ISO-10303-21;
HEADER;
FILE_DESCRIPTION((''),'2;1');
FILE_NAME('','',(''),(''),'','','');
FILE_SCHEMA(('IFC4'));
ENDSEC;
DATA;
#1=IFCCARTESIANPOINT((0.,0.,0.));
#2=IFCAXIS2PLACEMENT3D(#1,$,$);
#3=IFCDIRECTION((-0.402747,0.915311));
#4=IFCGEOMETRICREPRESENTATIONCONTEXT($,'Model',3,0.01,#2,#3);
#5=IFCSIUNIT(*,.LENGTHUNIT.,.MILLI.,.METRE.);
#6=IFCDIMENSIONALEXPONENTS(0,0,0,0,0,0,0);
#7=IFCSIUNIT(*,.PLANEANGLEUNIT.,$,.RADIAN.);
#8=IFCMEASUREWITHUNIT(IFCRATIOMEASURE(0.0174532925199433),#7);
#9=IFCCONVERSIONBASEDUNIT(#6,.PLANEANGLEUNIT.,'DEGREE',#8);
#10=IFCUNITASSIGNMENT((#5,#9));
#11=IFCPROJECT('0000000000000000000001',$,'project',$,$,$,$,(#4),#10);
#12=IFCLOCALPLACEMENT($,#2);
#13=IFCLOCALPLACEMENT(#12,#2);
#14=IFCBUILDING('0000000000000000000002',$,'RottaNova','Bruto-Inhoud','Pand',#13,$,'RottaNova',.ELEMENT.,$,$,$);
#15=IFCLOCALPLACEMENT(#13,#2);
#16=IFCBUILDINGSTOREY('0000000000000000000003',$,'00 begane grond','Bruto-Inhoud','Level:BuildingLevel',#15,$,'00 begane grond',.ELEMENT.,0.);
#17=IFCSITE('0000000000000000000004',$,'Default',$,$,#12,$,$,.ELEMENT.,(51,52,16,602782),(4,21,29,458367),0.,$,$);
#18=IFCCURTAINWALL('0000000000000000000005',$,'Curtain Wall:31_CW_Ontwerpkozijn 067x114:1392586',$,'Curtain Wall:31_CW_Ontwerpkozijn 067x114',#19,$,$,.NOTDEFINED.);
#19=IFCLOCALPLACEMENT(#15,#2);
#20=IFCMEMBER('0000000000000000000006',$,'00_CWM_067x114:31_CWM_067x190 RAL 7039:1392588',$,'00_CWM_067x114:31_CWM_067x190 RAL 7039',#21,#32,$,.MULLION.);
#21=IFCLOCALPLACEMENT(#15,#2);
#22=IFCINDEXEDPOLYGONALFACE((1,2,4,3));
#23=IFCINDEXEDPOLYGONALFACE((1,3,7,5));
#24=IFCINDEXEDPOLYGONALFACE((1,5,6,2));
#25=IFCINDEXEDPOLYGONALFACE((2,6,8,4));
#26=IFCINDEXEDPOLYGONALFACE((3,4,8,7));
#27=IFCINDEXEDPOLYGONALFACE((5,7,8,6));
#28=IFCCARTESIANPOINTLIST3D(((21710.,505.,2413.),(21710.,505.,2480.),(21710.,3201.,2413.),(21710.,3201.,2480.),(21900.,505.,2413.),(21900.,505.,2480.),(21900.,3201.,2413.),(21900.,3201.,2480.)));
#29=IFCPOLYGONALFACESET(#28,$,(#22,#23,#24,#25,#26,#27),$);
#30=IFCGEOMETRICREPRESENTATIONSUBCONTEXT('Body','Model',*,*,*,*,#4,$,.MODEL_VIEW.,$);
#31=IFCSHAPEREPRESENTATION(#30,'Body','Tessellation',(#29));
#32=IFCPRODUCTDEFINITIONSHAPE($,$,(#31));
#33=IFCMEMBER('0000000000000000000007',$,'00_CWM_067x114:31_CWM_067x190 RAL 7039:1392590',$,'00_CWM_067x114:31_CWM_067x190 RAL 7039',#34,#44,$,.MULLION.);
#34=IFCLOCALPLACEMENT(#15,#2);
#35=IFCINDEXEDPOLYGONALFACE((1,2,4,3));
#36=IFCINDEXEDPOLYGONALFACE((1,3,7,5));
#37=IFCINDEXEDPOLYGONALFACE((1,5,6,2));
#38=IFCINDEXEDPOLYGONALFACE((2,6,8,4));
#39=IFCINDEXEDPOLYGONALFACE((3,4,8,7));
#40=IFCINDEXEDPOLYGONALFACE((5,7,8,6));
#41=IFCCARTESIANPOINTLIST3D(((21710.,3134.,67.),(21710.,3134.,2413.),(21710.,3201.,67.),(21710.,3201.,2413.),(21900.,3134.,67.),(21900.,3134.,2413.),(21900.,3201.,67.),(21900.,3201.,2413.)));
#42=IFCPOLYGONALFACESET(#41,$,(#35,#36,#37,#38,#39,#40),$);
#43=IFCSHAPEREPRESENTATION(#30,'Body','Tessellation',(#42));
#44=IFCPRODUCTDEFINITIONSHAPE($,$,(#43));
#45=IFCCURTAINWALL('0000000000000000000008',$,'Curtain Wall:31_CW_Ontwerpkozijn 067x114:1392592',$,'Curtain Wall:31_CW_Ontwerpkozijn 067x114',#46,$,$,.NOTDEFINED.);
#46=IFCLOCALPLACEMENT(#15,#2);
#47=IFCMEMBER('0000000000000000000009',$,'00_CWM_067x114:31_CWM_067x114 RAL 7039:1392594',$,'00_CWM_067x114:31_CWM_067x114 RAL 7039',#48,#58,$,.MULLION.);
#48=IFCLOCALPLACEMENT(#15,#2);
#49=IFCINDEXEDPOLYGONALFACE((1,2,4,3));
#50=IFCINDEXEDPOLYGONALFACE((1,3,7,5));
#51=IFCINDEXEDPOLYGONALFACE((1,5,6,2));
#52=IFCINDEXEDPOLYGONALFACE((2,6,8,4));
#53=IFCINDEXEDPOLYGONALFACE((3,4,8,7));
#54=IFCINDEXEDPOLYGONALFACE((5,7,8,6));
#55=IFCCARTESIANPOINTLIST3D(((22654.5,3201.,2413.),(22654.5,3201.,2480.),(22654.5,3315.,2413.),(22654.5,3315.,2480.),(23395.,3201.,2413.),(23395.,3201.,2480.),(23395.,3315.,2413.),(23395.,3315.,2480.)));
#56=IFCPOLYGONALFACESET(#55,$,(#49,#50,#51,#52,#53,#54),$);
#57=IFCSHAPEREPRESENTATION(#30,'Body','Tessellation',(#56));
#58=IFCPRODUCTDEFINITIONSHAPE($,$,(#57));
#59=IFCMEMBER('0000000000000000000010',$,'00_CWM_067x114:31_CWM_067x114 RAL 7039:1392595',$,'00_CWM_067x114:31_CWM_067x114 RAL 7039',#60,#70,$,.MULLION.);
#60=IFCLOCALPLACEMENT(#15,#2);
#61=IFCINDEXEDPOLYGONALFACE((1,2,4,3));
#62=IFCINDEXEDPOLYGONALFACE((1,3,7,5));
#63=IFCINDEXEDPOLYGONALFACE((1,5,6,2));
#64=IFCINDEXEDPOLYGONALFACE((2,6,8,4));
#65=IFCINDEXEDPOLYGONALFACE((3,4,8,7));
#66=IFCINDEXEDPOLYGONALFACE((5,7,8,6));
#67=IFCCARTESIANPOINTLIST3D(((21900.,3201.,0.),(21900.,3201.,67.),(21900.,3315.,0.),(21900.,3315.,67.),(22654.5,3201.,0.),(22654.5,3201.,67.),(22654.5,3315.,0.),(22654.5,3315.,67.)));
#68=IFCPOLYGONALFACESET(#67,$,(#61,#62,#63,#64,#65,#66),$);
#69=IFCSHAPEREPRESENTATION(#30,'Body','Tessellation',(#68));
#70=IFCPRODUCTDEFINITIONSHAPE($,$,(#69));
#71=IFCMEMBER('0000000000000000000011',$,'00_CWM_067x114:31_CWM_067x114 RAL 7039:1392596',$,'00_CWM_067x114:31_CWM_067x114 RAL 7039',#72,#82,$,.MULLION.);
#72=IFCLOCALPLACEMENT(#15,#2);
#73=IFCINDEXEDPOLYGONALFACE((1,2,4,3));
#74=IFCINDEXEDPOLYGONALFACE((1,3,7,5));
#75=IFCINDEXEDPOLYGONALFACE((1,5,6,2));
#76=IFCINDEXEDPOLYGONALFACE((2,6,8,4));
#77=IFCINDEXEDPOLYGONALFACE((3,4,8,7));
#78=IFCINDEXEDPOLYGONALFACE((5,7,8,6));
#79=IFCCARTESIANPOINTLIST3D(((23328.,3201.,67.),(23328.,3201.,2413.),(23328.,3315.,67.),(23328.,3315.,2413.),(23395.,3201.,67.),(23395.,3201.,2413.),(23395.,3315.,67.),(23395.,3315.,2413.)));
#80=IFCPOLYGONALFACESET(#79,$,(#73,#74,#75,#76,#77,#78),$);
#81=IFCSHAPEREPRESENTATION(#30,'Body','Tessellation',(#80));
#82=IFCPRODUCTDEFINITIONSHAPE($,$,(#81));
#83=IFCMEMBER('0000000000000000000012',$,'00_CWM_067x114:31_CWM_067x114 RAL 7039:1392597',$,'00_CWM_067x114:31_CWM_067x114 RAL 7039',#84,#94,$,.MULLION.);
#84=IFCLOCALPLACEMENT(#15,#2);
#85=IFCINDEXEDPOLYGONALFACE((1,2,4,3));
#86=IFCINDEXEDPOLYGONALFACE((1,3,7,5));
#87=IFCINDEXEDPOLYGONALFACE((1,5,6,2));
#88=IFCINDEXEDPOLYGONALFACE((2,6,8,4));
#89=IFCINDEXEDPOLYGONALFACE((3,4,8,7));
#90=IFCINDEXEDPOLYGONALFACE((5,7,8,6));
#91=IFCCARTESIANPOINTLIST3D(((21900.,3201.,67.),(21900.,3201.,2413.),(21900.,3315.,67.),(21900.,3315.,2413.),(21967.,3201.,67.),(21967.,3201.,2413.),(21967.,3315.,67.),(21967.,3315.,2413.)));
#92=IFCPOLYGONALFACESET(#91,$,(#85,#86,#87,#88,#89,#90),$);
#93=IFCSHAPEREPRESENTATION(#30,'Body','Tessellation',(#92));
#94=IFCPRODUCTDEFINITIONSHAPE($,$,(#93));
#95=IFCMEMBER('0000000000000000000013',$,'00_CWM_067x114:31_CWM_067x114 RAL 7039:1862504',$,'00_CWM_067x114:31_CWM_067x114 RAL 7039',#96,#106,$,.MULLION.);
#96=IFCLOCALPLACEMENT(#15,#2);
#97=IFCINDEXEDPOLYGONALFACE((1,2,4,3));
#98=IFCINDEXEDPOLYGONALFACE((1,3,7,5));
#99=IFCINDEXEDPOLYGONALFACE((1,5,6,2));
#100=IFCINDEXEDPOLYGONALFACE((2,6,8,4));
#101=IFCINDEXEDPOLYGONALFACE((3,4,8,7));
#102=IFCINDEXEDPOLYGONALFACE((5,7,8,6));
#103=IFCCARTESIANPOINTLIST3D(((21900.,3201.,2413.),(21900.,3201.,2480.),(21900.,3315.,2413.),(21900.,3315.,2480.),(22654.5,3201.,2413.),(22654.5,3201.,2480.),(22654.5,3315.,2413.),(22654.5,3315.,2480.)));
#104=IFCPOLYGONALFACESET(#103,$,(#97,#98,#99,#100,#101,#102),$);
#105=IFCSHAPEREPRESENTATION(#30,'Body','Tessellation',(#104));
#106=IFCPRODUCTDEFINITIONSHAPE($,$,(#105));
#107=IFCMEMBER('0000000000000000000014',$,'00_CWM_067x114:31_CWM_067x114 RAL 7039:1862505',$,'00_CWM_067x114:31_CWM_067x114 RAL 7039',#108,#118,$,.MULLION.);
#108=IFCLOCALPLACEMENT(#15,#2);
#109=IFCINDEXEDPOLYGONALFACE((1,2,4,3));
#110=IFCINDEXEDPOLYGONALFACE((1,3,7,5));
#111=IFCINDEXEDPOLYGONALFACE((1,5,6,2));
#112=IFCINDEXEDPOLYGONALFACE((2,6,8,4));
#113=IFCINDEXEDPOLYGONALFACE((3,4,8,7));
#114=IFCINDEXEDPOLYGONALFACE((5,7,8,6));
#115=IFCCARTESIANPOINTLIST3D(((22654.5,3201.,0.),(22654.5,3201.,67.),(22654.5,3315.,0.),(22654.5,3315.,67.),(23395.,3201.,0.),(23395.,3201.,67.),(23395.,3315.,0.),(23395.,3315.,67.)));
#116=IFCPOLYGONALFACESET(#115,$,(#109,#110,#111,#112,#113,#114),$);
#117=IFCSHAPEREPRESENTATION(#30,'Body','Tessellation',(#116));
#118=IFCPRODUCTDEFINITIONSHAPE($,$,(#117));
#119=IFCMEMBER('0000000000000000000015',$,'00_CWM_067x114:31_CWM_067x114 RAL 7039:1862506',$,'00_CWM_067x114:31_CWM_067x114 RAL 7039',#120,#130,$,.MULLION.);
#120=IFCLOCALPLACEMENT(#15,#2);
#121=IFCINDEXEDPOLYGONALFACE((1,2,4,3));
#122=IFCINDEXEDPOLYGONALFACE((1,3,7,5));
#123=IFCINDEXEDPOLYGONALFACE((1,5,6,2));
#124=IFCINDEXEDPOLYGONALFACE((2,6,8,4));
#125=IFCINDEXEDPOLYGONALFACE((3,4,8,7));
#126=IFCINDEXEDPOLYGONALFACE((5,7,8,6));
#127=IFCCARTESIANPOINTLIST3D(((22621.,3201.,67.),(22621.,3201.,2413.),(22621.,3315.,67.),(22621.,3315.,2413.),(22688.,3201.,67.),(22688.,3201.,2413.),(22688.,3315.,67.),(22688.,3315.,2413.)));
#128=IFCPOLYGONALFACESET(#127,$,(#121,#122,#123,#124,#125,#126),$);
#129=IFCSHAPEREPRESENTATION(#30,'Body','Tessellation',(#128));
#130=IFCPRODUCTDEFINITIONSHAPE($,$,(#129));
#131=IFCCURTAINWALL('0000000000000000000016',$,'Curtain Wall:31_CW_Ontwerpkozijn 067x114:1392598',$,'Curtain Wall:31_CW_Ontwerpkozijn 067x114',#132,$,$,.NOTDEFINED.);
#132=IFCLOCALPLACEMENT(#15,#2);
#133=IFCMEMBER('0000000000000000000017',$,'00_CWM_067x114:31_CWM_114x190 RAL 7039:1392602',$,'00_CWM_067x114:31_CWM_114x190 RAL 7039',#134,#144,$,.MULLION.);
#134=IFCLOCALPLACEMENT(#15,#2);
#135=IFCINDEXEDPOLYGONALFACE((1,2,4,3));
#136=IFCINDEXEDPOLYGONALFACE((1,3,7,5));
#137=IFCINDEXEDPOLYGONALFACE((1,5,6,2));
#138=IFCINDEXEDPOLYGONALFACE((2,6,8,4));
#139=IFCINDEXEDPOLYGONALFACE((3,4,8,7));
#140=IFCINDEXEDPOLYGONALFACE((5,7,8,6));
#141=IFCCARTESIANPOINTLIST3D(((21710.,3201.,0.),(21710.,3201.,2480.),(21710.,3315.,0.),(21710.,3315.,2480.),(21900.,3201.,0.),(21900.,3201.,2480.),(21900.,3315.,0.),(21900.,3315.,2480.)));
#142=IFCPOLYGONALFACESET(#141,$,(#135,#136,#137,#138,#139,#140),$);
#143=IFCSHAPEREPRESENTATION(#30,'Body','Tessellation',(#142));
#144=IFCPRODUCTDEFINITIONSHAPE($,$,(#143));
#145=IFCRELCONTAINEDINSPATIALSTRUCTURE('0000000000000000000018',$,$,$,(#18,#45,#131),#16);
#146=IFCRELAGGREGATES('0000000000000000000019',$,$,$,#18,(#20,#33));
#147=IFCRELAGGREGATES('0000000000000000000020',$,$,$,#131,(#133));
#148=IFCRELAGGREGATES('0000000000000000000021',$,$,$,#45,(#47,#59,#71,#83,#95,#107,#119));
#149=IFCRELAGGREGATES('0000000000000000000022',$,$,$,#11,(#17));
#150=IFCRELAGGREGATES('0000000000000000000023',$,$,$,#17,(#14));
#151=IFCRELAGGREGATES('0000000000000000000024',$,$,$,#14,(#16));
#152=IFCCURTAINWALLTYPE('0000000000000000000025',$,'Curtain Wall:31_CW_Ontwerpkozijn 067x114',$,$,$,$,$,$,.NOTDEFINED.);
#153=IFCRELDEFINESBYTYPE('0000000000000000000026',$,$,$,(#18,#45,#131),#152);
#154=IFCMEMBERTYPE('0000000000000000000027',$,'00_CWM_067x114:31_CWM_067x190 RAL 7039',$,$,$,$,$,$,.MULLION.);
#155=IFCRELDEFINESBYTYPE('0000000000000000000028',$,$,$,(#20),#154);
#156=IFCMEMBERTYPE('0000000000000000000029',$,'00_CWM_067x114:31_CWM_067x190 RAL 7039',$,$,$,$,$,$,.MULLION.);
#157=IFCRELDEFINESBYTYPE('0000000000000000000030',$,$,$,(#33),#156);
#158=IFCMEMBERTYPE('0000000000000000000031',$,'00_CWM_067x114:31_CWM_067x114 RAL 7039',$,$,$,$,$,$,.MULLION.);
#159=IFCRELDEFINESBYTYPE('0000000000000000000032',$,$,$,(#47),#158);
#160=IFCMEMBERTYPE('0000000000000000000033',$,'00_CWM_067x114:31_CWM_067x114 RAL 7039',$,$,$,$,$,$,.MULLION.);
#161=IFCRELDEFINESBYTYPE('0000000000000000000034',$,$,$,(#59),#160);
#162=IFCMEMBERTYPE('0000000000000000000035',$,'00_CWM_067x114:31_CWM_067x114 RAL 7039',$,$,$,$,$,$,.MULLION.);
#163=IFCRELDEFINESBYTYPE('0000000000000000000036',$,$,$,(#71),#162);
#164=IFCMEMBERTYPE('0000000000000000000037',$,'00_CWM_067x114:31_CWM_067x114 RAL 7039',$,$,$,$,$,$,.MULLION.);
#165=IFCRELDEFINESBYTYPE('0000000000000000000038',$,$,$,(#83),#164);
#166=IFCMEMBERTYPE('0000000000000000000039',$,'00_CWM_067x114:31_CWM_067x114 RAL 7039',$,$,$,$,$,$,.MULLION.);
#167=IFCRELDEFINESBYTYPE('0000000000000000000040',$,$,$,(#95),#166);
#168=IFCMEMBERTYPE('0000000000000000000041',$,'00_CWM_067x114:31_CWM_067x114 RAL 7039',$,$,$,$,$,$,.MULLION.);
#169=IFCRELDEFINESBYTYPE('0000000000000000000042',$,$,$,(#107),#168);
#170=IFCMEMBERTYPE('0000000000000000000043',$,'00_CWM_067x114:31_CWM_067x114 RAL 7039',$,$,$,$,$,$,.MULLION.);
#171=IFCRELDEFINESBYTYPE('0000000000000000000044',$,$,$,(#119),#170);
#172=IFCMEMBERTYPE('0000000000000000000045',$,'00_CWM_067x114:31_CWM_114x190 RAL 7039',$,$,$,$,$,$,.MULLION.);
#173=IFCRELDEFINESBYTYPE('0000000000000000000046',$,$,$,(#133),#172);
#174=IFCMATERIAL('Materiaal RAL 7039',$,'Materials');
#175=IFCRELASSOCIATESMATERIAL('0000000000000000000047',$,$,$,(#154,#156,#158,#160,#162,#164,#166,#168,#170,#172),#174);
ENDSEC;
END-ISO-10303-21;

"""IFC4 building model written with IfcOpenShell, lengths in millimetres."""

from ifc_helpers import new_model, entity, si_unit, converted_unit, direction, frame, origin, origin_2d_with_axis, place, context, subcontext, project, spatial, rectangle, extrude, source, transform, mapped, material, material_profile, profile_set, type_object, type_shapes, element, aggregate, save


model = new_model("IFC4")

# Units and contexts
model_context = context("Model", 3, precision=0.01, world=origin(), true_north=direction((-0.402747, 0.915311)))
body_context = subcontext(model_context, "Body", "Model", "MODEL_VIEW")
ifc_project = project(units=[si_unit("LENGTHUNIT", "METRE", prefix="MILLI"), converted_unit("PLANEANGLEUNIT", "DEGREE", entity("IfcRatioMeasure", 0.0174532925199433), si_unit("PLANEANGLEUNIT", "RADIAN"), dimensions=[0, 0, 0, 0, 0, 0, 0])], contexts=[model_context])

# Site, building, storey
site_placement = place(None, origin())
site = spatial("IfcSite", under=ifc_project, at=site_placement, Name="Default", CompositionType="ELEMENT", RefLatitude=(51, 52, 16, 602782), RefLongitude=(4, 21, 29, 458367), RefElevation=0.0)
building_placement = place(site_placement, origin())
building = spatial("IfcBuilding", under=site, at=building_placement, Name="RottaNova", Description="Bruto-Inhoud", ObjectType="Pand", LongName="RottaNova", CompositionType="ELEMENT")
storey_placement = place(building_placement, origin())
storey = spatial("IfcBuildingStorey", under=building, at=storey_placement, Name="00 begane grond", Description="Bruto-Inhoud", ObjectType="Level:BuildingLevel", LongName="00 begane grond", CompositionType="ELEMENT", Elevation=0.0)

# Curtain walls, members
curtain_wall_type = type_object("IfcCurtainWallType", Name="Curtain Wall:31_CW_Ontwerpkozijn 067x114", PredefinedType="NOTDEFINED")
curtain_wall_1_placement = place(storey_placement, origin())
curtain_wall_1 = element("IfcCurtainWall", 1, at=curtain_wall_1_placement, inside=storey, type_object=curtain_wall_type, Name="Curtain Wall:31_CW_Ontwerpkozijn 067x114:1392586", ObjectType="Curtain Wall:31_CW_Ontwerpkozijn 067x114", PredefinedType="NOTDEFINED")
ifc_material_1 = material(Name="Materiaal RAL 7039", Category="Materials")
ifc_material_profile_1 = material_profile(ifc_material_1, rectangle(XDim=190.0, YDim=67.0, at=origin_2d_with_axis()), Name="31_CWM_067x190 RAL 7039")
ifc_profile_set_1 = profile_set([ifc_material_profile_1], Name="31_CWM_067x190 RAL 7039")
member_type_1 = type_object("IfcMemberType", Name="00_CWM_067x114:31_CWM_067x190 RAL 7039", PredefinedType="MULLION", material=ifc_profile_set_1)
shared_shape_1 = source(origin(), body_context, "Body", "SweptSolid", [
    extrude(rectangle(XDim=190.0, YDim=67.0, at=origin_2d_with_axis()), frame((-33.5, 95.0, -2696.0), z_axis=(0.0, 0.0, 1.0), x_axis=(0.0, -1.0, 0.0)), (0.0, 0.0, 1.0), 2696.0),
])
type_shapes(member_type_1, [shared_shape_1])
member_1_placement = place(curtain_wall_1_placement, frame((21710.0, 3201.0, 2480.0), z_axis=(0.0, 1.0, 0.0), x_axis=(0.0, 0.0, 1.0)))
member_1 = element("IfcMember", 2, at=member_1_placement, type_object=member_type_1, Name="00_CWM_067x114:31_CWM_067x190 RAL 7039:1392588", ObjectType="00_CWM_067x114:31_CWM_067x190 RAL 7039", PredefinedType="MULLION", context=body_context, shape_type="MappedRepresentation", body=[
    mapped(shared_shape_1, transform((0.0, 0.0, 0.0), scale=1.0)),
])
member_type_2 = type_object("IfcMemberType", Name="00_CWM_067x114:31_CWM_067x190 RAL 7039", PredefinedType="MULLION", material=ifc_profile_set_1)
shared_shape_2 = source(origin(), body_context, "Body", "SweptSolid", [
    extrude(rectangle(XDim=190.0, YDim=67.0, at=origin_2d_with_axis()), frame((-33.5, 95.0, -2346.0), z_axis=(0.0, 0.0, 1.0), x_axis=(0.0, -1.0, 0.0)), (0.0, 0.0, 1.0), 2346.0),
])
type_shapes(member_type_2, [shared_shape_2])
member_2_placement = place(curtain_wall_1_placement, frame((21710.0, 3201.0, 67.0), z_axis=(0.0, 0.0, -1.0), x_axis=(0.0, 1.0, 0.0)))
member_2 = element("IfcMember", 3, at=member_2_placement, type_object=member_type_2, Name="00_CWM_067x114:31_CWM_067x190 RAL 7039:1392590", ObjectType="00_CWM_067x114:31_CWM_067x190 RAL 7039", PredefinedType="MULLION", context=body_context, shape_type="MappedRepresentation", body=[
    mapped(shared_shape_2, transform((0.0, 0.0, 0.0), scale=1.0)),
])
aggregate(curtain_wall_1, [member_1, member_2])
curtain_wall_2_placement = place(storey_placement, origin())
curtain_wall_2 = element("IfcCurtainWall", 4, at=curtain_wall_2_placement, inside=storey, type_object=curtain_wall_type, Name="Curtain Wall:31_CW_Ontwerpkozijn 067x114:1392592", ObjectType="Curtain Wall:31_CW_Ontwerpkozijn 067x114", PredefinedType="NOTDEFINED")
ifc_material_profile_2 = material_profile(ifc_material_1, rectangle(XDim=114.0, YDim=67.0, at=origin_2d_with_axis()), Name="31_CWM_067x114 RAL 7039")
ifc_profile_set_2 = profile_set([ifc_material_profile_2], Name="31_CWM_067x114 RAL 7039")
member_type_3 = type_object("IfcMemberType", Name="00_CWM_067x114:31_CWM_067x114 RAL 7039", PredefinedType="MULLION", material=ifc_profile_set_2)
shared_shape_3 = source(origin(), body_context, "Body", "SweptSolid", [
    extrude(rectangle(XDim=114.0, YDim=67.0, at=origin_2d_with_axis()), frame((-33.5, 57.0, -740.5), z_axis=(0.0, 0.0, 1.0), x_axis=(0.0, -1.0, 0.0)), (0.0, 0.0, 1.0), 740.5),
])
type_shapes(member_type_3, [shared_shape_3])
member_3_placement = place(curtain_wall_2_placement, frame((23395.0, 3315.0, 2480.0), z_axis=(1.0, 0.0, 0.0), x_axis=(0.0, 0.0, 1.0)))
member_3 = element("IfcMember", 5, at=member_3_placement, type_object=member_type_3, Name="00_CWM_067x114:31_CWM_067x114 RAL 7039:1392594", ObjectType="00_CWM_067x114:31_CWM_067x114 RAL 7039", PredefinedType="MULLION", context=body_context, shape_type="MappedRepresentation", body=[
    mapped(shared_shape_3, transform((0.0, 0.0, 0.0), scale=1.0)),
])
member_type_4 = type_object("IfcMemberType", Name="00_CWM_067x114:31_CWM_067x114 RAL 7039", PredefinedType="MULLION", material=ifc_profile_set_2)
shared_shape_4 = source(origin(), body_context, "Body", "SweptSolid", [
    extrude(rectangle(XDim=114.0, YDim=67.0, at=origin_2d_with_axis()), frame((-33.5, 57.0, -754.5), z_axis=(0.0, 0.0, 1.0), x_axis=(0.0, -1.0, 0.0)), (0.0, 0.0, 1.0), 754.5),
])
type_shapes(member_type_4, [shared_shape_4])
member_4_placement = place(curtain_wall_2_placement, frame((21900.0, 3315.0, 0.0), z_axis=(-1.0, 0.0, 0.0), x_axis=(0.0, 0.0, -1.0)))
member_4 = element("IfcMember", 6, at=member_4_placement, type_object=member_type_4, Name="00_CWM_067x114:31_CWM_067x114 RAL 7039:1392595", ObjectType="00_CWM_067x114:31_CWM_067x114 RAL 7039", PredefinedType="MULLION", context=body_context, shape_type="MappedRepresentation", body=[
    mapped(shared_shape_4, transform((0.0, 0.0, 0.0), scale=1.0)),
])
member_type_5 = type_object("IfcMemberType", Name="00_CWM_067x114:31_CWM_067x114 RAL 7039", PredefinedType="MULLION", material=ifc_profile_set_2)
shared_shape_5 = source(origin(), body_context, "Body", "SweptSolid", [
    extrude(rectangle(XDim=114.0, YDim=67.0, at=origin_2d_with_axis()), frame((-33.5, 57.0, -2346.0), z_axis=(0.0, 0.0, 1.0), x_axis=(0.0, -1.0, 0.0)), (0.0, 0.0, 1.0), 2346.0),
])
type_shapes(member_type_5, [shared_shape_5])
member_5_placement = place(curtain_wall_2_placement, frame((23395.0, 3315.0, 67.0), z_axis=(0.0, 0.0, -1.0), x_axis=(1.0, 0.0, 0.0)))
member_5 = element("IfcMember", 7, at=member_5_placement, type_object=member_type_5, Name="00_CWM_067x114:31_CWM_067x114 RAL 7039:1392596", ObjectType="00_CWM_067x114:31_CWM_067x114 RAL 7039", PredefinedType="MULLION", context=body_context, shape_type="MappedRepresentation", body=[
    mapped(shared_shape_5, transform((0.0, 0.0, 0.0), scale=1.0)),
])
member_type_6 = type_object("IfcMemberType", Name="00_CWM_067x114:31_CWM_067x114 RAL 7039", PredefinedType="MULLION", material=ifc_profile_set_2)
shared_shape_6 = source(origin(), body_context, "Body", "SweptSolid", [
    extrude(rectangle(XDim=114.0, YDim=67.0, at=origin_2d_with_axis()), frame((-33.5, 57.0, -2346.0), z_axis=(0.0, 0.0, 1.0), x_axis=(0.0, -1.0, 0.0)), (0.0, 0.0, 1.0), 2346.0),
])
type_shapes(member_type_6, [shared_shape_6])
member_6_placement = place(curtain_wall_2_placement, frame((21900.0, 3315.0, 2413.0), z_axis=(0.0, 0.0, 1.0), x_axis=(-1.0, 0.0, 0.0)))
member_6 = element("IfcMember", 8, at=member_6_placement, type_object=member_type_6, Name="00_CWM_067x114:31_CWM_067x114 RAL 7039:1392597", ObjectType="00_CWM_067x114:31_CWM_067x114 RAL 7039", PredefinedType="MULLION", context=body_context, shape_type="MappedRepresentation", body=[
    mapped(shared_shape_6, transform((0.0, 0.0, 0.0), scale=1.0)),
])
member_type_7 = type_object("IfcMemberType", Name="00_CWM_067x114:31_CWM_067x114 RAL 7039", PredefinedType="MULLION", material=ifc_profile_set_2)
shared_shape_7 = source(origin(), body_context, "Body", "SweptSolid", [
    extrude(rectangle(XDim=114.0, YDim=67.0, at=origin_2d_with_axis()), frame((-33.5, 57.0, -754.5), z_axis=(0.0, 0.0, 1.0), x_axis=(0.0, -1.0, 0.0)), (0.0, 0.0, 1.0), 754.5),
])
type_shapes(member_type_7, [shared_shape_7])
member_7_placement = place(curtain_wall_2_placement, frame((22654.5, 3315.0, 2480.0), z_axis=(1.0, 0.0, 0.0), x_axis=(0.0, 0.0, 1.0)))
member_7 = element("IfcMember", 9, at=member_7_placement, type_object=member_type_7, Name="00_CWM_067x114:31_CWM_067x114 RAL 7039:1862504", ObjectType="00_CWM_067x114:31_CWM_067x114 RAL 7039", PredefinedType="MULLION", context=body_context, shape_type="MappedRepresentation", body=[
    mapped(shared_shape_7, transform((0.0, 0.0, 0.0), scale=1.0)),
])
member_type_8 = type_object("IfcMemberType", Name="00_CWM_067x114:31_CWM_067x114 RAL 7039", PredefinedType="MULLION", material=ifc_profile_set_2)
shared_shape_8 = source(origin(), body_context, "Body", "SweptSolid", [
    extrude(rectangle(XDim=114.0, YDim=67.0, at=origin_2d_with_axis()), frame((-33.5, 57.0, -740.5), z_axis=(0.0, 0.0, 1.0), x_axis=(0.0, -1.0, 0.0)), (0.0, 0.0, 1.0), 740.5),
])
type_shapes(member_type_8, [shared_shape_8])
member_8_placement = place(curtain_wall_2_placement, frame((22654.5, 3315.0, 0.0), z_axis=(-1.0, 0.0, 0.0), x_axis=(0.0, 0.0, -1.0)))
member_8 = element("IfcMember", 10, at=member_8_placement, type_object=member_type_8, Name="00_CWM_067x114:31_CWM_067x114 RAL 7039:1862505", ObjectType="00_CWM_067x114:31_CWM_067x114 RAL 7039", PredefinedType="MULLION", context=body_context, shape_type="MappedRepresentation", body=[
    mapped(shared_shape_8, transform((0.0, 0.0, 0.0), scale=1.0)),
])
member_type_9 = type_object("IfcMemberType", Name="00_CWM_067x114:31_CWM_067x114 RAL 7039", PredefinedType="MULLION", material=ifc_profile_set_2)
shared_shape_9 = source(origin(), body_context, "Body", "SweptSolid", [
    extrude(rectangle(XDim=114.0, YDim=67.0, at=origin_2d_with_axis()), frame((0.0, 57.0, -2346.0), z_axis=(0.0, 0.0, 1.0), x_axis=(0.0, -1.0, 0.0)), (0.0, 0.0, 1.0), 2346.0),
])
type_shapes(member_type_9, [shared_shape_9])
member_9_placement = place(curtain_wall_2_placement, frame((22654.5, 3315.0, 67.0), z_axis=(0.0, 0.0, -1.0), x_axis=(1.0, 0.0, 0.0)))
member_9 = element("IfcMember", 11, at=member_9_placement, type_object=member_type_9, Name="00_CWM_067x114:31_CWM_067x114 RAL 7039:1862506", ObjectType="00_CWM_067x114:31_CWM_067x114 RAL 7039", PredefinedType="MULLION", context=body_context, shape_type="MappedRepresentation", body=[
    mapped(shared_shape_9, transform((0.0, 0.0, 0.0), scale=1.0)),
])

# Curtain wall, member
curtain_wall_3_placement = place(storey_placement, origin())
curtain_wall_3 = element("IfcCurtainWall", 12, at=curtain_wall_3_placement, inside=storey, type_object=curtain_wall_type, Name="Curtain Wall:31_CW_Ontwerpkozijn 067x114:1392598", ObjectType="Curtain Wall:31_CW_Ontwerpkozijn 067x114", PredefinedType="NOTDEFINED")
ifc_material_profile_3 = material_profile(ifc_material_1, rectangle(XDim=114.0, YDim=190.0, at=origin_2d_with_axis()), Name="31_CWM_114x190 RAL 7039")
ifc_profile_set_3 = profile_set([ifc_material_profile_3], Name="31_CWM_114x190 RAL 7039")
member_type_10 = type_object("IfcMemberType", Name="00_CWM_067x114:31_CWM_114x190 RAL 7039", PredefinedType="MULLION", material=ifc_profile_set_3)
shared_shape_10 = source(origin(), body_context, "Body", "SweptSolid", [
    extrude(rectangle(XDim=114.0, YDim=190.0, at=origin_2d_with_axis()), frame((-95.0, 0.0, -2480.0), z_axis=(0.0, 0.0, 1.0), x_axis=(0.0, -1.0, 0.0)), (0.0, 0.0, 1.0), 2480.0),
])
type_shapes(member_type_10, [shared_shape_10])
member_10_placement = place(curtain_wall_3_placement, frame((21710.0, 3258.0, 2480.0), z_axis=(0.0, 0.0, 1.0), x_axis=(-1.0, 0.0, 0.0)))
member_10 = element("IfcMember", 13, at=member_10_placement, type_object=member_type_10, Name="00_CWM_067x114:31_CWM_114x190 RAL 7039:1392602", ObjectType="00_CWM_067x114:31_CWM_114x190 RAL 7039", PredefinedType="MULLION", context=body_context, shape_type="MappedRepresentation", body=[
    mapped(shared_shape_10, transform((0.0, 0.0, 0.0), scale=1.0)),
])
aggregate(curtain_wall_3, [member_10])

aggregate(curtain_wall_2, [member_3, member_4, member_5, member_6, member_7, member_8, member_9])

save(model, "model.ifc")
